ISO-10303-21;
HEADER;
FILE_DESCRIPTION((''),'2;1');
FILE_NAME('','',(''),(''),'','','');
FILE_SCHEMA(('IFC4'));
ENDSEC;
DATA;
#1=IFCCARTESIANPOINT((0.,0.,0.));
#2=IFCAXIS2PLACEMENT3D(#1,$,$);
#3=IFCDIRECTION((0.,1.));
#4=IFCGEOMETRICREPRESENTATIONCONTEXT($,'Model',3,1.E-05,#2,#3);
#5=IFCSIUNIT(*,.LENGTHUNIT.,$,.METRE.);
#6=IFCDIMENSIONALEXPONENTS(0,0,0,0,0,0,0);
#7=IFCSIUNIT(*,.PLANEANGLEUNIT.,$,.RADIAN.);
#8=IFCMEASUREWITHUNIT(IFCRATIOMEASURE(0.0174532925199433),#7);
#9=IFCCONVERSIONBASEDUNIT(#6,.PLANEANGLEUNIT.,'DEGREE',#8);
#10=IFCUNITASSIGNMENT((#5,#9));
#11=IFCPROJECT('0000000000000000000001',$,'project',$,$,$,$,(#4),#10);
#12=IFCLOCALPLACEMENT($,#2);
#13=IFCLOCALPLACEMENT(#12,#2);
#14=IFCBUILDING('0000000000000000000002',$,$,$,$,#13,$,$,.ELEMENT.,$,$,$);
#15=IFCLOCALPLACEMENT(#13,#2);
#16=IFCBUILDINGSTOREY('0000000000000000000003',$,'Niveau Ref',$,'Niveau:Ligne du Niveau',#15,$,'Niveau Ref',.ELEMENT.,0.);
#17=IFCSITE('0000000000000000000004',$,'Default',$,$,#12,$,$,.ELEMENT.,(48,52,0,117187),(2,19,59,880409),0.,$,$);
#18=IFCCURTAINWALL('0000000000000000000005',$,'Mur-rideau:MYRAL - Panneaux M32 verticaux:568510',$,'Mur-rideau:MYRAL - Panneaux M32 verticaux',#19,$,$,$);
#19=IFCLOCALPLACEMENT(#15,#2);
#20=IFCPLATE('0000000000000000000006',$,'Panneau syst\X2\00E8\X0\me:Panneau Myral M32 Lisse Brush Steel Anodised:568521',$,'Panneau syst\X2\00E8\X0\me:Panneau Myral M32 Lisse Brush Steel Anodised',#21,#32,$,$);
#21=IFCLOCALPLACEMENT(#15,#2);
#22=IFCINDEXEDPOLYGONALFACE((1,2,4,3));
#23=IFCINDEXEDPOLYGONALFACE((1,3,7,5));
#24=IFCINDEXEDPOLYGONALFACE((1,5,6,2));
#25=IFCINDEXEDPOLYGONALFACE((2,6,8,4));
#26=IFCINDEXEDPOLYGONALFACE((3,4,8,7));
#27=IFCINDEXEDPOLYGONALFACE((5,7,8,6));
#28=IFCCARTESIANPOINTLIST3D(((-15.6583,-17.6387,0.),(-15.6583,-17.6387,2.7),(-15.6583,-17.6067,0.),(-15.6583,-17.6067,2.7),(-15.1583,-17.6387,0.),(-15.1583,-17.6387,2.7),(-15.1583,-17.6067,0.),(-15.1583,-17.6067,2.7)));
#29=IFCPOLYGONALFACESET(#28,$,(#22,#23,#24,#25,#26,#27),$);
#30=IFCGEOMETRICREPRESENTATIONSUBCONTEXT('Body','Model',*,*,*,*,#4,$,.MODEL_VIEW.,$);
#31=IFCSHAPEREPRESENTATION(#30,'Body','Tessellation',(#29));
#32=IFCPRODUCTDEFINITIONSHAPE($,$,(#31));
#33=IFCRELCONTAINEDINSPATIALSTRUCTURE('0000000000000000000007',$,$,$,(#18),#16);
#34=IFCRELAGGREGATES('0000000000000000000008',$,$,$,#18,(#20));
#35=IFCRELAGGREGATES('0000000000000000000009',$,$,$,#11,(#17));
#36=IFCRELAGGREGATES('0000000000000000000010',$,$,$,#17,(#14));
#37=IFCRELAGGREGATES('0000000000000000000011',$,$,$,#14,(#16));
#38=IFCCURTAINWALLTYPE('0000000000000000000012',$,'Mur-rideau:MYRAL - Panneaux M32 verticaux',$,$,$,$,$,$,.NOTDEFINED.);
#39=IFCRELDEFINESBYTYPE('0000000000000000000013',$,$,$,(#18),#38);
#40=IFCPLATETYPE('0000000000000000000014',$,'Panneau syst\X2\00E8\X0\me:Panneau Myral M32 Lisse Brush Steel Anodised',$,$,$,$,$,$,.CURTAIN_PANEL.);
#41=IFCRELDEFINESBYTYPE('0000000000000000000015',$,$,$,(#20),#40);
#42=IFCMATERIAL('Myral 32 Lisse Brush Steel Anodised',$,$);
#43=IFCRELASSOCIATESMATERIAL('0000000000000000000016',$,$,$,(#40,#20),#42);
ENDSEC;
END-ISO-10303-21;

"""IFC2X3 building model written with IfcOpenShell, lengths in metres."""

from ifc_helpers import new_model, entity, si_unit, converted_unit, direction, frame, origin, origin_2d_with_axis, place, context, subcontext, project, spatial, rectangle, extrude, source, transform, mapped, material, type_object, type_shapes, element, aggregate, save


model = new_model("IFC2X3")

# Units and contexts
model_context = context("Model", 3, precision=1e-05, world=origin(), true_north=direction((0.0, 1.0)))
body_context = subcontext(model_context, "Body", "Model", "MODEL_VIEW")
ifc_project = project(units=[si_unit("LENGTHUNIT", "METRE"), converted_unit("PLANEANGLEUNIT", "DEGREE", entity("IfcRatioMeasure", 0.0174532925199433), si_unit("PLANEANGLEUNIT", "RADIAN"), dimensions=[0, 0, 0, 0, 0, 0, 0])], contexts=[model_context])

# Site, building, storey
site_placement = place(None, origin())
site = spatial("IfcSite", under=ifc_project, at=site_placement, Name="Default", CompositionType="ELEMENT", RefLatitude=(48, 52, 0, 117187), RefLongitude=(2, 19, 59, 880409), RefElevation=0.0)
building_placement = place(site_placement, origin())
building = spatial("IfcBuilding", under=site, at=building_placement, CompositionType="ELEMENT")
storey_placement = place(building_placement, origin())
storey = spatial("IfcBuildingStorey", under=building, at=storey_placement, Name="Niveau Ref", ObjectType="Niveau:Ligne du Niveau", LongName="Niveau Ref", CompositionType="ELEMENT", Elevation=0.0)

# Curtain wall, plate
curtain_wall_type_1 = type_object("IfcCurtainWallType", Name="Mur-rideau:MYRAL - Panneaux M32 verticaux", PredefinedType="NOTDEFINED")
curtain_wall_1_placement = place(storey_placement, origin())
curtain_wall_1 = element("IfcCurtainWall", 1, at=curtain_wall_1_placement, inside=storey, type_object=curtain_wall_type_1, Name="Mur-rideau:MYRAL - Panneaux M32 verticaux:568510", ObjectType="Mur-rideau:MYRAL - Panneaux M32 verticaux")
ifc_material_1 = material(Name="Myral 32 Lisse Brush Steel Anodised")
plate_type = type_object("IfcPlateType", Name="Panneau système:Panneau Myral M32 Lisse Brush Steel Anodised", PredefinedType="CURTAIN_PANEL", material=ifc_material_1)
shared_shape_1 = source(origin(), body_context, "Body", "SweptSolid", [
    extrude(rectangle(XDim=0.032, YDim=0.5, at=origin_2d_with_axis()), frame((0.0, -0.016, 0.0), z_axis=(0.0, 0.0, 1.0), x_axis=(0.0, 1.0, 0.0)), (0.0, 0.0, 1.0), 2.7),
])
type_shapes(plate_type, [shared_shape_1])
plate_1_placement = place(curtain_wall_1_placement, frame((-15.4083, -17.6067, 0.0)))
plate_1 = element("IfcPlate", 2, at=plate_1_placement, type_object=plate_type, material=ifc_material_1, Name="Panneau système:Panneau Myral M32 Lisse Brush Steel Anodised:568521", ObjectType="Panneau système:Panneau Myral M32 Lisse Brush Steel Anodised", context=body_context, shape_type="MappedRepresentation", body=[
    mapped(shared_shape_1, transform((0.0, 0.0, 0.0), scale=1.0)),
])
aggregate(curtain_wall_1, [plate_1])

save(model, "model.ifc")
